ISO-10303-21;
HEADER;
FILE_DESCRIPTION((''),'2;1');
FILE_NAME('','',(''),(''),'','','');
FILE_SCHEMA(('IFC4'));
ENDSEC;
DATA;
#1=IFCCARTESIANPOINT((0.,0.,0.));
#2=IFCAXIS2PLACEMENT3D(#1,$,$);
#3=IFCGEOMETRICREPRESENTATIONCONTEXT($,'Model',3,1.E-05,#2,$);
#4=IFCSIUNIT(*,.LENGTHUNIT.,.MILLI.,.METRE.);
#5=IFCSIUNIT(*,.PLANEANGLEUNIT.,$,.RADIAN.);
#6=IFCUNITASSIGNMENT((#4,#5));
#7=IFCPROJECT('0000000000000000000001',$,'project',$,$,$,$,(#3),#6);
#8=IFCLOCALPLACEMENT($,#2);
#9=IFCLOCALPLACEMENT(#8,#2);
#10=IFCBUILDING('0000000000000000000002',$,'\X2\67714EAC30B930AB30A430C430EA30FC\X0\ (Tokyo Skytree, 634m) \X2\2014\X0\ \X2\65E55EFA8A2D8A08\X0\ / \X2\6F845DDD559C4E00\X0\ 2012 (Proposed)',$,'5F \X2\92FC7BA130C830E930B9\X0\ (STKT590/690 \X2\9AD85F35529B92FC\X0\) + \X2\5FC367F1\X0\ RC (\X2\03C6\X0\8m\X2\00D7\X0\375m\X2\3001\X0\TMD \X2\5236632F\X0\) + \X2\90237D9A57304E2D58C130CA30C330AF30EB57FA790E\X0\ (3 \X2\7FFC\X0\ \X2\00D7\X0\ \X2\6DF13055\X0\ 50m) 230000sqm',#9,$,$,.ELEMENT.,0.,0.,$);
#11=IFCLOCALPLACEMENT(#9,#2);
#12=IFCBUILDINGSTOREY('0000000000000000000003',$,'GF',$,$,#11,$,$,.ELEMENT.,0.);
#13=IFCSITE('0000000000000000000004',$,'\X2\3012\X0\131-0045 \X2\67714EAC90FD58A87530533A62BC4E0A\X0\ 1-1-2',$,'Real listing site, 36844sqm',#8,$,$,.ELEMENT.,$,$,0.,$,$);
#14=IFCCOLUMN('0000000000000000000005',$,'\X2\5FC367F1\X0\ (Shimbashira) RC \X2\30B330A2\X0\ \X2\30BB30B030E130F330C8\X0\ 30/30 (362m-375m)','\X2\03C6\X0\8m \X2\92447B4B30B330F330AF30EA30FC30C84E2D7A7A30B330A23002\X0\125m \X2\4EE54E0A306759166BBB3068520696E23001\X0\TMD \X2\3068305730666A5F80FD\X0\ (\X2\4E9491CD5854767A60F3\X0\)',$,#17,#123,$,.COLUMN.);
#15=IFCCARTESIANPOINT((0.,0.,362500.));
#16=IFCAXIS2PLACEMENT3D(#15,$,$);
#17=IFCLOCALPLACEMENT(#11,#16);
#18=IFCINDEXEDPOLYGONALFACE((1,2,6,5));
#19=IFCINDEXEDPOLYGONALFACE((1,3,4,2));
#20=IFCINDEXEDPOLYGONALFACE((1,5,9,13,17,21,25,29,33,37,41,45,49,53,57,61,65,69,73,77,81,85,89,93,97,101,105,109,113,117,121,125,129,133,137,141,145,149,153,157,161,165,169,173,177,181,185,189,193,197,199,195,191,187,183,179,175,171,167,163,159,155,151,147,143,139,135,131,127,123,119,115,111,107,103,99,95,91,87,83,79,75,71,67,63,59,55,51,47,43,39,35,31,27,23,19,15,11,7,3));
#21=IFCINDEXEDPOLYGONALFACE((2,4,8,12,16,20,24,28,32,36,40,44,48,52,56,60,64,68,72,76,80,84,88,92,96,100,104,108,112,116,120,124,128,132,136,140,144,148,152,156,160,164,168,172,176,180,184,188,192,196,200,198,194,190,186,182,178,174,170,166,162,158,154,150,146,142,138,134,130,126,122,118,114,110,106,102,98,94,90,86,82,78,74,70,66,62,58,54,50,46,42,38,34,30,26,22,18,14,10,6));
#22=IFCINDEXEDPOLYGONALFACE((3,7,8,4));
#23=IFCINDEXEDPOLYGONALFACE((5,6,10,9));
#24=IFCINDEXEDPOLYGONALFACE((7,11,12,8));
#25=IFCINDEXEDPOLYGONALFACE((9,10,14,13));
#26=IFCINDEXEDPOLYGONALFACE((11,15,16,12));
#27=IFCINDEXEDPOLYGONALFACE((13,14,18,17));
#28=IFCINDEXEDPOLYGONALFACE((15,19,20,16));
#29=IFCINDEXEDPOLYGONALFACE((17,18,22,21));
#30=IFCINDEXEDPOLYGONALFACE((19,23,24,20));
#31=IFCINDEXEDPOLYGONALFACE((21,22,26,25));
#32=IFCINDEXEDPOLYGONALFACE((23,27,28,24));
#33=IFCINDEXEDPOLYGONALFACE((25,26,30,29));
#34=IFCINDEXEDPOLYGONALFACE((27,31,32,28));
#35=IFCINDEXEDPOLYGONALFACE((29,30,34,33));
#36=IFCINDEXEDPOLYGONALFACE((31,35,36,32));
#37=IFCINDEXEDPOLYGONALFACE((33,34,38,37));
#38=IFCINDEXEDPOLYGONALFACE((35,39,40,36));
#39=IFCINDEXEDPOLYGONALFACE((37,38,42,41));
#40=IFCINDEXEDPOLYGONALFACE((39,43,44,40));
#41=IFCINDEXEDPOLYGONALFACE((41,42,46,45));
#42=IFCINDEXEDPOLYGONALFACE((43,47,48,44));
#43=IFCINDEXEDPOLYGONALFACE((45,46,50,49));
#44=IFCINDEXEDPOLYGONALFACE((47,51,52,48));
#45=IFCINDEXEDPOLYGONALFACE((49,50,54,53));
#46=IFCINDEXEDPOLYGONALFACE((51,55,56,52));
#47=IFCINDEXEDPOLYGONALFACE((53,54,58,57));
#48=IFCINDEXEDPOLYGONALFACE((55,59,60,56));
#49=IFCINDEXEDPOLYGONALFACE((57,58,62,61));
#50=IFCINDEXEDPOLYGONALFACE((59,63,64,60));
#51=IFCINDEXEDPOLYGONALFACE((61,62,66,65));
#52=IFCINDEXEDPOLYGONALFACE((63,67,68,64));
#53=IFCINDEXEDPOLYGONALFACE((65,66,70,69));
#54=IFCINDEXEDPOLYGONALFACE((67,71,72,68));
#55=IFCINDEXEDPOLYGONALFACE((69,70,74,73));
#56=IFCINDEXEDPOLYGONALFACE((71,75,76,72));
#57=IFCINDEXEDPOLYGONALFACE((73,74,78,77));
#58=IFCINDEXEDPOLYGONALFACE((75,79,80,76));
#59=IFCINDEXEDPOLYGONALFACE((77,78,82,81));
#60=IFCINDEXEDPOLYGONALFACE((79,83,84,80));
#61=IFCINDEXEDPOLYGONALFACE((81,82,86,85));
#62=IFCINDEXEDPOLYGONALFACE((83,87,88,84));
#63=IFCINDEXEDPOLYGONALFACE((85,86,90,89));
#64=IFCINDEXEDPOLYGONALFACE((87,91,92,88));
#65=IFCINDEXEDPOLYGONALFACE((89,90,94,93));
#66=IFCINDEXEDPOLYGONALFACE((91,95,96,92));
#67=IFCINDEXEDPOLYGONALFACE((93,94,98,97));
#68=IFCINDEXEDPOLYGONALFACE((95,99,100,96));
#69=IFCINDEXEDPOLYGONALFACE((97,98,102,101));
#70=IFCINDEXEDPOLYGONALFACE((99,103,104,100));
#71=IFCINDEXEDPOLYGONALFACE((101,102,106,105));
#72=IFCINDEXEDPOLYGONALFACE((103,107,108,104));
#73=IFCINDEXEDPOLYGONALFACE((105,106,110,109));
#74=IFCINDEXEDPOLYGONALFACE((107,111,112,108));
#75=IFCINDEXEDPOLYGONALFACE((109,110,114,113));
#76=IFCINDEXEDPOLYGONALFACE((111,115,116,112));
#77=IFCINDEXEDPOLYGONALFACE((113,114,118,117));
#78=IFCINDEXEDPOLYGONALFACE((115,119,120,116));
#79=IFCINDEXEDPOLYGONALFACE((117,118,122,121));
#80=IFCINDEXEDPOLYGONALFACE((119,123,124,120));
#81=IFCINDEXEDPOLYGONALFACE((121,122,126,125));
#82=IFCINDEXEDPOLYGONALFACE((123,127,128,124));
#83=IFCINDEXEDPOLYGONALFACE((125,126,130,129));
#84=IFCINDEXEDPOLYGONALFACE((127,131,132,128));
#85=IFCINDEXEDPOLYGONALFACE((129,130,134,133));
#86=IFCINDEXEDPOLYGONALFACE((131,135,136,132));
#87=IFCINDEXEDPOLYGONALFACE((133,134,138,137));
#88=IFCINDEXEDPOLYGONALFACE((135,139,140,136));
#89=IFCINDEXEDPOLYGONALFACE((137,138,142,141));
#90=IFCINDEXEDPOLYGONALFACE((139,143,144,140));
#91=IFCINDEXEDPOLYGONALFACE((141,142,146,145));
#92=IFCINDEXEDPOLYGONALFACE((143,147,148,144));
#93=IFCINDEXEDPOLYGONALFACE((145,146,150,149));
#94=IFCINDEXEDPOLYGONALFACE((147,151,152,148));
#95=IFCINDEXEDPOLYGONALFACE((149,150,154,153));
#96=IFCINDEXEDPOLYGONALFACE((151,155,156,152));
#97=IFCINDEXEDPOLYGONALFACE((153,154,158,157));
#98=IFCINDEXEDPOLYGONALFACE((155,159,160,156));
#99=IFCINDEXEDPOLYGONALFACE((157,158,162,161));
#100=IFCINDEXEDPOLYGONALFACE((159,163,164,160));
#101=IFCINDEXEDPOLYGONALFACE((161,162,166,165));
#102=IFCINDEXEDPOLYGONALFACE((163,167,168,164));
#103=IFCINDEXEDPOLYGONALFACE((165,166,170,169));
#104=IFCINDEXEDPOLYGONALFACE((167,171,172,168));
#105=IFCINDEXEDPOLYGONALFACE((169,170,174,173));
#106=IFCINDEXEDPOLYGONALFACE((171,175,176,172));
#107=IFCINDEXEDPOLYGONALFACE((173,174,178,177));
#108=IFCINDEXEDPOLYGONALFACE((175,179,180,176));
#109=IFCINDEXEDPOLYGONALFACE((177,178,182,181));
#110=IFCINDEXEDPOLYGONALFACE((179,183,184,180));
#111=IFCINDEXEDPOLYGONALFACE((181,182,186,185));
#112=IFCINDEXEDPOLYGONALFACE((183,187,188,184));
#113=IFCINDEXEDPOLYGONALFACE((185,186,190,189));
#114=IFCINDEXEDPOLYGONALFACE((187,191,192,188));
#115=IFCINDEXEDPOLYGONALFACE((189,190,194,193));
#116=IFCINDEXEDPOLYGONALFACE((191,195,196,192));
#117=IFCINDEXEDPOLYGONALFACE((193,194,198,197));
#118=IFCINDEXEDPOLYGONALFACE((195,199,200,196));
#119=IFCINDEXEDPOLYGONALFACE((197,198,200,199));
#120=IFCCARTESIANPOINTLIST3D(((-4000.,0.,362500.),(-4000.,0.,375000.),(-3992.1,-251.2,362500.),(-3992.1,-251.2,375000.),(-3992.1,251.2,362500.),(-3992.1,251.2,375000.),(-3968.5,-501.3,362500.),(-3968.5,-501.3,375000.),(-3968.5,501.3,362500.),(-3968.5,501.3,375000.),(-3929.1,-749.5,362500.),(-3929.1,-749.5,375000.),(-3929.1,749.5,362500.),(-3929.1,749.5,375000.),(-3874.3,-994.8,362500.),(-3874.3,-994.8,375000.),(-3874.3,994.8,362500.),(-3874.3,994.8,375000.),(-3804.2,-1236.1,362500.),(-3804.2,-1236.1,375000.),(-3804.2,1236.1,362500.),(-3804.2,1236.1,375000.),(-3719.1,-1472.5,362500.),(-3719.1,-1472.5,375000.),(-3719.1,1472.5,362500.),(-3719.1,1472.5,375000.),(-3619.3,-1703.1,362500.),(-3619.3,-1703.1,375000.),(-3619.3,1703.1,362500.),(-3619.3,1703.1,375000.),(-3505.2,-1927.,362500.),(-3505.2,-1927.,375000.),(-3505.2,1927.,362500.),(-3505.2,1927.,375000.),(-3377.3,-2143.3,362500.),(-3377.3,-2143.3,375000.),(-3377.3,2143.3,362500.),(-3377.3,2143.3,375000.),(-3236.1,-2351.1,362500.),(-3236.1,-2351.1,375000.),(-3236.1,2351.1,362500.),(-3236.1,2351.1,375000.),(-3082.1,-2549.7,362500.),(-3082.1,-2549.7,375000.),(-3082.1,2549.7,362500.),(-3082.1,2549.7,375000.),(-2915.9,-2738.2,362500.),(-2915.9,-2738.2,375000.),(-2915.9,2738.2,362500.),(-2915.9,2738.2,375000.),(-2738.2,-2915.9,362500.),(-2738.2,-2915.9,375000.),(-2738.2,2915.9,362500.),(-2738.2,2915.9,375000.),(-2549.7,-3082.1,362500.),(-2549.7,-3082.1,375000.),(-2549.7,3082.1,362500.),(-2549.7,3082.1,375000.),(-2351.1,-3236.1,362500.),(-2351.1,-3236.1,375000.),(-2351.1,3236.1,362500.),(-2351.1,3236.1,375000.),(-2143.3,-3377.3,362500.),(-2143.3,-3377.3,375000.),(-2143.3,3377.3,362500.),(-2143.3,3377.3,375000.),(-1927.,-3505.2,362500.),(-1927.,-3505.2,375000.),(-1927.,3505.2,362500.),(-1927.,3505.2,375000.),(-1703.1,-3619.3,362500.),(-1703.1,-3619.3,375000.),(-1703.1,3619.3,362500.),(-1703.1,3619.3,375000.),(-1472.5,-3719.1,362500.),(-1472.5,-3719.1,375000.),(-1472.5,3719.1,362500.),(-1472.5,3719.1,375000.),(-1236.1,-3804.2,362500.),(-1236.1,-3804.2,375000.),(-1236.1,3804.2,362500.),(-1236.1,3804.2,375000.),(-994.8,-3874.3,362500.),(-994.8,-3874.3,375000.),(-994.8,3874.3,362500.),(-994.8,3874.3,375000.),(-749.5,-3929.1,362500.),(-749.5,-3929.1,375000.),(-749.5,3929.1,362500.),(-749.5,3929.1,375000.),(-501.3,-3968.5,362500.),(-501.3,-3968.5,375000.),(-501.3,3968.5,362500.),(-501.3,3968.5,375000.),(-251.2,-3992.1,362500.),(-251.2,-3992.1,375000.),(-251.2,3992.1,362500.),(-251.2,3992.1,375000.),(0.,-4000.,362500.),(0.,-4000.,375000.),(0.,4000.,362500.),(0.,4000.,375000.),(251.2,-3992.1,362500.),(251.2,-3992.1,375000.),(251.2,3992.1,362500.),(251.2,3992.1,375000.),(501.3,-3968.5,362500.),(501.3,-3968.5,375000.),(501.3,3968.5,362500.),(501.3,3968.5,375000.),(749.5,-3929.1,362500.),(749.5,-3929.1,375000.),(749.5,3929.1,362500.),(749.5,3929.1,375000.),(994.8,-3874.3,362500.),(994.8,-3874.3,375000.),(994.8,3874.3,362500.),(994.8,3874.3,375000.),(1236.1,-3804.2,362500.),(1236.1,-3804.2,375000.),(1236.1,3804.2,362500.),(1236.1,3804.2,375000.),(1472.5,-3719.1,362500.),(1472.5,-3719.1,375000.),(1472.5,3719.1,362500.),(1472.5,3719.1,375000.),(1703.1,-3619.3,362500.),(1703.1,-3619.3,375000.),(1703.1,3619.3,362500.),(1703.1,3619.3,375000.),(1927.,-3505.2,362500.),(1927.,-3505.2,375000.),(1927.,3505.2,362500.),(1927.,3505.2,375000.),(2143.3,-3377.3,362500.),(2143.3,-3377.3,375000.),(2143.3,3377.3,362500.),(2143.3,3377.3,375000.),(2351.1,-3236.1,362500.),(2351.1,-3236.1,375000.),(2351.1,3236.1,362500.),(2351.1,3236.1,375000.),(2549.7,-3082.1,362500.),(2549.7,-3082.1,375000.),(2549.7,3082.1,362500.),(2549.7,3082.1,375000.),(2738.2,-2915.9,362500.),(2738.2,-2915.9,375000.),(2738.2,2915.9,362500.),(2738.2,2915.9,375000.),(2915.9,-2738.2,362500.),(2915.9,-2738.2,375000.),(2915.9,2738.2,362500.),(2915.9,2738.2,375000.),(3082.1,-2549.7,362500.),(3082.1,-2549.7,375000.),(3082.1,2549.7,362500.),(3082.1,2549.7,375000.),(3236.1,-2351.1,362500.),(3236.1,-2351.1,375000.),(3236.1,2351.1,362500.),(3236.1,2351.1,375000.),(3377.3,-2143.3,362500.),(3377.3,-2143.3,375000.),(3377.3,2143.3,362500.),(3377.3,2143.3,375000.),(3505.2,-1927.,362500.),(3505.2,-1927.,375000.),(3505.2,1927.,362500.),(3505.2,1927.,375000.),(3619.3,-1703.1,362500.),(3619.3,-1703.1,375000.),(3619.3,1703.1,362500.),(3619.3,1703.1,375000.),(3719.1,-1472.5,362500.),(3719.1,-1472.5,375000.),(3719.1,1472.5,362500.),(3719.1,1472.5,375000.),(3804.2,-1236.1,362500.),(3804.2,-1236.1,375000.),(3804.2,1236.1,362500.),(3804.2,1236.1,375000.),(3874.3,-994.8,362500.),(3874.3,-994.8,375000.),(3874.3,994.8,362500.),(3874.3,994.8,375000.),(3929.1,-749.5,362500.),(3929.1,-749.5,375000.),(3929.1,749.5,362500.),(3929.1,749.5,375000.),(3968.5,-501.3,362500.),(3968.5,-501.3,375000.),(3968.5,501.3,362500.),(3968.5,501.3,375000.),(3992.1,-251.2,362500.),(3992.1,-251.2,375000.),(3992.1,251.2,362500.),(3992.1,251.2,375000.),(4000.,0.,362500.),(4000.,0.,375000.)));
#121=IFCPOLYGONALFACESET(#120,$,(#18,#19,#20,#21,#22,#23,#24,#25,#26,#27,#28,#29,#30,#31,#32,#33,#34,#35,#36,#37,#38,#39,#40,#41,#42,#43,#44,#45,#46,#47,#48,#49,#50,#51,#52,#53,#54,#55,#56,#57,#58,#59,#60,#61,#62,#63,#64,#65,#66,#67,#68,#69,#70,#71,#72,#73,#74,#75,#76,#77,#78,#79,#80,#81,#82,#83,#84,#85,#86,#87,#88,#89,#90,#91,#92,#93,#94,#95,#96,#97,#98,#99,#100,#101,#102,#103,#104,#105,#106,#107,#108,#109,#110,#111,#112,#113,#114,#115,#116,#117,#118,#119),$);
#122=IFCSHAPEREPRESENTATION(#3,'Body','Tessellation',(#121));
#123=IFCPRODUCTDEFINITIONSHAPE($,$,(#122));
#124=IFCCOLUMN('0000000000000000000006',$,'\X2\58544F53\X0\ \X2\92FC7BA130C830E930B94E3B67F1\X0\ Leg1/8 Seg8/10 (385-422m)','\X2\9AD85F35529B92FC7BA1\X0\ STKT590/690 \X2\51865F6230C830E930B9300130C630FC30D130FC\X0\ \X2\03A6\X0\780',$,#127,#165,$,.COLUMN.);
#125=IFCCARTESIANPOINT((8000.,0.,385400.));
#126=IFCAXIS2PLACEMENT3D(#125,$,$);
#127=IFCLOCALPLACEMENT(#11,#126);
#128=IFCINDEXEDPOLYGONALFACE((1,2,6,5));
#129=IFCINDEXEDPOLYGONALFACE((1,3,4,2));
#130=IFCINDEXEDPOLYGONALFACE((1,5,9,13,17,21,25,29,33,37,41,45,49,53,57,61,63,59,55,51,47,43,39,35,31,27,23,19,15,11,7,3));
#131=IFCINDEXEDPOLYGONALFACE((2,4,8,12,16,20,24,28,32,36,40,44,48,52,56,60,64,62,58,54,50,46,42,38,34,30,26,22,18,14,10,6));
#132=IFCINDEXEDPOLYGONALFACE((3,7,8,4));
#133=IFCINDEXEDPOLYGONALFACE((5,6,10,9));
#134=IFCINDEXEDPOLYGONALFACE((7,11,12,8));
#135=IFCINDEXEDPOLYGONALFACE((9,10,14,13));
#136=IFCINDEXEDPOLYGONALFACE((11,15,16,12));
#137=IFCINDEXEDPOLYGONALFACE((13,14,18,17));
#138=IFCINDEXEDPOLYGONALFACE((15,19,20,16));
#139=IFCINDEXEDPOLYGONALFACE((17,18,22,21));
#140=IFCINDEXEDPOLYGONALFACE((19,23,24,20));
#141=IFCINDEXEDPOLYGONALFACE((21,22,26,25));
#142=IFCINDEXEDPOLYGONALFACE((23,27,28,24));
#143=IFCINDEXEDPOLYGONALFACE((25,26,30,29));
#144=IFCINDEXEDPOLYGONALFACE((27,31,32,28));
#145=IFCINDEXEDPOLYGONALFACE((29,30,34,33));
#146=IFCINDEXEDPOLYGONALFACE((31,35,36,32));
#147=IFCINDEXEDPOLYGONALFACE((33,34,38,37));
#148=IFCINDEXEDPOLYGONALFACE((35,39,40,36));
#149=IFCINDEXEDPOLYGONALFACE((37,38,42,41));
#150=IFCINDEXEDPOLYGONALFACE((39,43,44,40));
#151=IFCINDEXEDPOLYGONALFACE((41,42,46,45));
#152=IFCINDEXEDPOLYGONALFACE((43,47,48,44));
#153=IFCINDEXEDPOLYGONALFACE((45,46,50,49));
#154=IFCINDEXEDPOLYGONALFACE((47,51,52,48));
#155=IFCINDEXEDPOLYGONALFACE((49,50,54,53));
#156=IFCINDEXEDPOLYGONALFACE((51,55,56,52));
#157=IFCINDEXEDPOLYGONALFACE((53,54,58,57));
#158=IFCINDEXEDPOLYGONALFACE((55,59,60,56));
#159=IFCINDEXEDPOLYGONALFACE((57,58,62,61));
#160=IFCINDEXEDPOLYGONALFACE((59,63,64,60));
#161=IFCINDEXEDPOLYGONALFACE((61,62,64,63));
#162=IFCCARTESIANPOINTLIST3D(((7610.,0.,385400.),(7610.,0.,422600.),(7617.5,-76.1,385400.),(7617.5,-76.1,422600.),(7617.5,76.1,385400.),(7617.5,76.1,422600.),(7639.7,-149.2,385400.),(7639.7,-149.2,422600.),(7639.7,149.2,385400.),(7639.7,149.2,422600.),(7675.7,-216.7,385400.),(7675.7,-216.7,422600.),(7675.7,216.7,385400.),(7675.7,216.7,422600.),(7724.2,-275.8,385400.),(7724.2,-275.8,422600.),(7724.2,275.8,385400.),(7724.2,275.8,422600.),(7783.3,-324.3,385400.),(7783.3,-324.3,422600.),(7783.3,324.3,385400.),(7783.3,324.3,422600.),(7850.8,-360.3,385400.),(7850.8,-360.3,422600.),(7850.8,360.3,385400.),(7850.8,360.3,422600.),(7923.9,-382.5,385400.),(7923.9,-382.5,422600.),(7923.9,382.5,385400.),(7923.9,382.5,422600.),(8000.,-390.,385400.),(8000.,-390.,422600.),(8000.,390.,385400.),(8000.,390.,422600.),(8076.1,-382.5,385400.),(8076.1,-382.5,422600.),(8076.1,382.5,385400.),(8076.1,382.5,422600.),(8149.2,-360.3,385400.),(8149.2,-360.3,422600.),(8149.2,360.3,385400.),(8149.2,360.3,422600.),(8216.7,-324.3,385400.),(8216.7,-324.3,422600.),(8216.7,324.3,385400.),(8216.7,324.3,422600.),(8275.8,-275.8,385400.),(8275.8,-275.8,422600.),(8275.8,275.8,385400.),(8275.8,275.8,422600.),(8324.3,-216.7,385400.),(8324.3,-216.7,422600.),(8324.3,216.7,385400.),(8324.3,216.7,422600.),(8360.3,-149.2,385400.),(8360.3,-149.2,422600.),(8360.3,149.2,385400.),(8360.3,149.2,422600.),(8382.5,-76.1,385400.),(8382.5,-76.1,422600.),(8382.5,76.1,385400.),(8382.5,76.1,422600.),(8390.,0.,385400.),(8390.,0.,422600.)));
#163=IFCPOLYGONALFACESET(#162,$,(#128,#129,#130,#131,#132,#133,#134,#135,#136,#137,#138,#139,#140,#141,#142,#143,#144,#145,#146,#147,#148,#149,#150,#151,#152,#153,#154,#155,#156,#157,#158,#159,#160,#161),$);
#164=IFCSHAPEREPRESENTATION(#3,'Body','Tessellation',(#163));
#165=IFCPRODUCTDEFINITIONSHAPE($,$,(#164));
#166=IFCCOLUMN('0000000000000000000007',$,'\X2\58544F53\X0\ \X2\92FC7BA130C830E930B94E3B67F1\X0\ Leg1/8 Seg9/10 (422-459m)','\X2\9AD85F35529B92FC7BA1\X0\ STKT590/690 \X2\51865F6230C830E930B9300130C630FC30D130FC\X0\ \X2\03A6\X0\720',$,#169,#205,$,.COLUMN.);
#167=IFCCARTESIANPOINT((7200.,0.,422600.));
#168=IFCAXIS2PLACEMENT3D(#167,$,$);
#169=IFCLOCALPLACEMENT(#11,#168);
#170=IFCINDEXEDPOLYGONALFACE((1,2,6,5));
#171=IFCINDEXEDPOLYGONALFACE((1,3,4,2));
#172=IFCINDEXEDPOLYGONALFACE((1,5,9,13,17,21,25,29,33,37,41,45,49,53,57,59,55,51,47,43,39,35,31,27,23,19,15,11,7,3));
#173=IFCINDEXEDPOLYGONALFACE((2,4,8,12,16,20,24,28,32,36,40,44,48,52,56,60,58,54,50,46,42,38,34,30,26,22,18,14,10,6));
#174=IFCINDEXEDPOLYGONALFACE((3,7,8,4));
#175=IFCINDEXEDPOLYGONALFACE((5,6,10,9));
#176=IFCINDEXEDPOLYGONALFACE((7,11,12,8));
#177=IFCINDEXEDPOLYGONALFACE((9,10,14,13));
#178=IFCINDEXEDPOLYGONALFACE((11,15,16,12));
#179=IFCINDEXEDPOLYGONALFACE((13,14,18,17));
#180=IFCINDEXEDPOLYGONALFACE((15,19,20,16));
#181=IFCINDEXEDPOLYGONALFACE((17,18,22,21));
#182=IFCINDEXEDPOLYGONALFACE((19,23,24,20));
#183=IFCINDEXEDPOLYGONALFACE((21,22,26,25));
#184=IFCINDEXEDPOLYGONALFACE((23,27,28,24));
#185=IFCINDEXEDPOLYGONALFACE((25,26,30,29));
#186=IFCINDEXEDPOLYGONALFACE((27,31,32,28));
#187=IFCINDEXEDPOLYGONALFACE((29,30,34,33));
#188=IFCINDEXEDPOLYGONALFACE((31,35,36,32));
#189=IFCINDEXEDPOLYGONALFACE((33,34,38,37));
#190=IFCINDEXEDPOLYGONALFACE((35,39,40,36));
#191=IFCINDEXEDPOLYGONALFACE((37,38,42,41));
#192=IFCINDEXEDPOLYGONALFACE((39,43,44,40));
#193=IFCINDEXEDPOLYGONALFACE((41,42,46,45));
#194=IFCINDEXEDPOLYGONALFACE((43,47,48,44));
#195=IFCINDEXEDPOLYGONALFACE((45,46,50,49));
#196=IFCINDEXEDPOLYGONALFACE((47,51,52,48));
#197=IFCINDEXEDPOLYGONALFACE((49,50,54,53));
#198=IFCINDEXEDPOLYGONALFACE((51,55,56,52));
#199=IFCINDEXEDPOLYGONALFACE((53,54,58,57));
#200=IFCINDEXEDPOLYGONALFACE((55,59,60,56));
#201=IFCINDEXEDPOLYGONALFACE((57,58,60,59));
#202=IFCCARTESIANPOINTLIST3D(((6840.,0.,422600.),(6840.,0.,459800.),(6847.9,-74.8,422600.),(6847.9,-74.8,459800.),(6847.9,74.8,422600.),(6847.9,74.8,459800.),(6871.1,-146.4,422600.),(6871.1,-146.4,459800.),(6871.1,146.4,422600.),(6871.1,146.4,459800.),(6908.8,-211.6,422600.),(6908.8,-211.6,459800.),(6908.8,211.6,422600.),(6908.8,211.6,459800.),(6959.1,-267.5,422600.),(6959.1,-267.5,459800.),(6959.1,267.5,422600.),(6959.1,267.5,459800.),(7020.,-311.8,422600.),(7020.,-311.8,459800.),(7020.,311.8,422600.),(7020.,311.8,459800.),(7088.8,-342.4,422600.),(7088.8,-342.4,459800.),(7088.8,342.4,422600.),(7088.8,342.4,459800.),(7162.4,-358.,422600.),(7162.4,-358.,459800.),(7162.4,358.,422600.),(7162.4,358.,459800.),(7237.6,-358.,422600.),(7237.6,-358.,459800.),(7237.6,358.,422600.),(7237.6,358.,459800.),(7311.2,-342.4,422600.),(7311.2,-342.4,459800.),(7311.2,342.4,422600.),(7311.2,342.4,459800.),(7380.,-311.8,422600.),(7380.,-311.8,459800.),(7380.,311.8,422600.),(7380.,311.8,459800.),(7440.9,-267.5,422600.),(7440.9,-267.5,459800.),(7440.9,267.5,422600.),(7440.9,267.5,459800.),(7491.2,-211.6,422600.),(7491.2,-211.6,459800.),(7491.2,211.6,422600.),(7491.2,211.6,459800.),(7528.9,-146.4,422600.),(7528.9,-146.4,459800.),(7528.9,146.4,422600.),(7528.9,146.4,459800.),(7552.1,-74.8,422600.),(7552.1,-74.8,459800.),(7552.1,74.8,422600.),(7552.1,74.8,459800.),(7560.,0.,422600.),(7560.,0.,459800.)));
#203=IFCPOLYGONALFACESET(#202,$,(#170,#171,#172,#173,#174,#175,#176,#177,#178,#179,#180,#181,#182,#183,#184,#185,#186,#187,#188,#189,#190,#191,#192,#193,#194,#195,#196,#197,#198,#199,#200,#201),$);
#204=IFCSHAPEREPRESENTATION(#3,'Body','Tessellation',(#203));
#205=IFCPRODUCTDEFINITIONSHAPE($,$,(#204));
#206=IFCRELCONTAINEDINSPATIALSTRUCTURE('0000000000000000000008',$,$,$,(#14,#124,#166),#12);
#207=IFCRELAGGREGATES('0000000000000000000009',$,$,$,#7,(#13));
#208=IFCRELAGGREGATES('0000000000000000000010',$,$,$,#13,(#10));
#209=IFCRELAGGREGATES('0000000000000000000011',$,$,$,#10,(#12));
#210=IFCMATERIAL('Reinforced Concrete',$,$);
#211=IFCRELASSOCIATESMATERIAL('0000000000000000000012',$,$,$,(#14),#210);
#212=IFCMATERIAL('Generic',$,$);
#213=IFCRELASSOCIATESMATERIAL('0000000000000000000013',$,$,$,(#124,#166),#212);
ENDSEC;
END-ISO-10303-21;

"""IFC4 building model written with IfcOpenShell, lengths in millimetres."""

from ifc_helpers import new_model, si_unit, frame, origin, origin_2d, place, context, project, spatial, circle, extrude, material, element, save


model = new_model("IFC4")

# Units and contexts
model_context = context("Model", 3, precision=1e-05, world=origin())
ifc_project = project(units=[si_unit("LENGTHUNIT", "METRE", prefix="MILLI"), si_unit("PLANEANGLEUNIT", "RADIAN")], contexts=[model_context])

# Site, building, storey
site_placement = place(None, origin())
site = spatial("IfcSite", under=ifc_project, at=site_placement, Name="〒131-0045 東京都墨田区押上 1-1-2", ObjectType="Real listing site, 36844sqm", CompositionType="ELEMENT", RefElevation=0.0)
building_placement = place(site_placement, origin())
building = spatial("IfcBuilding", under=site, at=building_placement, Name="東京スカイツリー (Tokyo Skytree, 634m) — 日建設計 / 澄川喜一 2012 (Proposed)", ObjectType="5F 鋼管トラス (STKT590/690 高張力鋼) + 心柱 RC (φ8m×375m、TMD 制振) + 連続地中壁ナックル基礎 (3 翼 × 深さ 50m) 230000sqm", CompositionType="ELEMENT", ElevationOfRefHeight=0.0, ElevationOfTerrain=0.0)
storey_placement = place(building_placement, origin())
storey = spatial("IfcBuildingStorey", under=building, at=storey_placement, Name="GF", CompositionType="ELEMENT", Elevation=0.0)

# Columns
ifc_material_1 = material(Name="Reinforced Concrete")
column_1_placement = place(storey_placement, frame((0.0, 0.0, 362500.0)))
element("IfcColumn", 1, at=column_1_placement, inside=storey, material=ifc_material_1, Name="心柱 (Shimbashira) RC コア セグメント 30/30 (362m-375m)", Description="φ8m 鉄筋コンクリート中空コア。125m 以上で外殻と分離、TMD として機能 (五重塔発想)", PredefinedType="COLUMN", context=model_context, shape_type="SweptSolid", body=[
    extrude(circle(Radius=4000.0, at=origin_2d()), frame((0.0, 0.0, 362500.0)), (0.0, 0.0, 1.0), 12500.0),
])
ifc_material_2 = material(Name="Generic")
column_2_placement = place(storey_placement, frame((8000.0, 0.0, 385400.0)))
element("IfcColumn", 2, at=column_2_placement, inside=storey, material=ifc_material_2, Name="塔体 鋼管トラス主柱 Leg1/8 Seg8/10 (385-422m)", Description="高張力鋼管 STKT590/690 円形トラス、テーパー Φ780", PredefinedType="COLUMN", context=model_context, shape_type="SweptSolid", body=[
    extrude(circle(Radius=390.0, at=origin_2d()), frame((8000.0, 0.0, 385400.0)), (0.0, 0.0, 1.0), 37200.0),
])
column_3_placement = place(storey_placement, frame((7200.0, 0.0, 422600.0)))
element("IfcColumn", 3, at=column_3_placement, inside=storey, material=ifc_material_2, Name="塔体 鋼管トラス主柱 Leg1/8 Seg9/10 (422-459m)", Description="高張力鋼管 STKT590/690 円形トラス、テーパー Φ720", PredefinedType="COLUMN", context=model_context, shape_type="SweptSolid", body=[
    extrude(circle(Radius=360.0, at=origin_2d()), frame((7200.0, 0.0, 422600.0)), (0.0, 0.0, 1.0), 37200.0),
])

save(model, "model.ifc")
